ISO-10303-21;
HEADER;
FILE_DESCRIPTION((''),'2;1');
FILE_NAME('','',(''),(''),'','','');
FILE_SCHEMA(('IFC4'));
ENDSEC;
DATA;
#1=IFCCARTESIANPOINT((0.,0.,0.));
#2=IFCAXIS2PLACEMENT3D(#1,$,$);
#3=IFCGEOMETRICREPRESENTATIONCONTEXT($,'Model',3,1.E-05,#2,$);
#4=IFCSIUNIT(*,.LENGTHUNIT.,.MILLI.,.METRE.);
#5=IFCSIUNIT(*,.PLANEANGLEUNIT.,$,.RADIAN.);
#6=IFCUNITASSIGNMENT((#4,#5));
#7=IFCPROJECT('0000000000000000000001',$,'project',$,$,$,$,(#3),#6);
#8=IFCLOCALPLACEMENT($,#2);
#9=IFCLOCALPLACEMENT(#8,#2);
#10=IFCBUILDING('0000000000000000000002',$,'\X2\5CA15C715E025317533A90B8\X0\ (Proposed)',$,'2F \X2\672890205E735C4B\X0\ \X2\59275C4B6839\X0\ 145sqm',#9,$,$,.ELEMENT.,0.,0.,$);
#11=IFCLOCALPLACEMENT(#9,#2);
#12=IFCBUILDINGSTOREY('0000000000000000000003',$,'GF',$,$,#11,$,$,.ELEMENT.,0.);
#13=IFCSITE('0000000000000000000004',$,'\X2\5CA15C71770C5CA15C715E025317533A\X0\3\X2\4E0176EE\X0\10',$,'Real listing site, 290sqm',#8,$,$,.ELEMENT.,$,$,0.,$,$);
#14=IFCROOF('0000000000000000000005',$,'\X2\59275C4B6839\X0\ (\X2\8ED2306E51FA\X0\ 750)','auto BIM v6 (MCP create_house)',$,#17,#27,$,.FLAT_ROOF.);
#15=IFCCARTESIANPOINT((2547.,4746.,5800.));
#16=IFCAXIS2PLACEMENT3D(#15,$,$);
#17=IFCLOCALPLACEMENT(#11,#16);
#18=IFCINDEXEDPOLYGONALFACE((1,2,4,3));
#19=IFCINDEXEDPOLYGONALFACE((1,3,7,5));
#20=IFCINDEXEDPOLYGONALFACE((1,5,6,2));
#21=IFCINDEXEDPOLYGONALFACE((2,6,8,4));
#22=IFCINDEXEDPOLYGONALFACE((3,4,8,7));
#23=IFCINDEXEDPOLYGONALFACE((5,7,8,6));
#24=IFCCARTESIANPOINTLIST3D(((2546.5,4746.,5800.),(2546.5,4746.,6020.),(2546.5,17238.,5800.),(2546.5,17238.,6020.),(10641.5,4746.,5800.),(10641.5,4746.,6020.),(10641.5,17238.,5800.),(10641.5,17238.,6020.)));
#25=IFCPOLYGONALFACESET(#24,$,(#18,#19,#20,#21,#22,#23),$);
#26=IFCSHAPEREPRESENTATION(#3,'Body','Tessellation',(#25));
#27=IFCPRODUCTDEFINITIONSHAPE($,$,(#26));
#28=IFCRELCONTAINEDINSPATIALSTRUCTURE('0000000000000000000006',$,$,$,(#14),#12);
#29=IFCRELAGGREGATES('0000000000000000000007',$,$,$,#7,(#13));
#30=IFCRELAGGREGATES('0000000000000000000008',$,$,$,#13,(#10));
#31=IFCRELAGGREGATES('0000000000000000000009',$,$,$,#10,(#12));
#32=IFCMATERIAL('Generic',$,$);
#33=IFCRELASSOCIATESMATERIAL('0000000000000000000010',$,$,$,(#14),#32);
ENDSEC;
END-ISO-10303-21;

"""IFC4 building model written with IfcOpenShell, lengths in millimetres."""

from ifc_helpers import new_model, si_unit, frame, frame_2d, origin, place, context, project, spatial, rectangle, extrude, material, element, save


model = new_model("IFC4")

# Units and contexts
model_context = context("Model", 3, precision=1e-05, world=origin())
ifc_project = project(units=[si_unit("LENGTHUNIT", "METRE", prefix="MILLI"), si_unit("PLANEANGLEUNIT", "RADIAN")], contexts=[model_context])

# Site, building, storey
site_placement = place(None, origin())
site = spatial("IfcSite", under=ifc_project, at=site_placement, Name="岡山県岡山市北区3丁目10", ObjectType="Real listing site, 290sqm", CompositionType="ELEMENT", RefElevation=0.0)
building_placement = place(site_placement, origin())
building = spatial("IfcBuilding", under=site, at=building_placement, Name="岡山市北区邸 (Proposed)", ObjectType="2F 木造平屋 大屋根 145sqm", CompositionType="ELEMENT", ElevationOfRefHeight=0.0, ElevationOfTerrain=0.0)
storey_placement = place(building_placement, origin())
storey = spatial("IfcBuildingStorey", under=building, at=storey_placement, Name="GF", CompositionType="ELEMENT", Elevation=0.0)

# Shared definitions
ifc_material = material(Name="Generic")

# Roof
roof_placement = place(storey_placement, frame((2547.0, 4746.0, 5800.0)))
element("IfcRoof", 1, at=roof_placement, inside=storey, material=ifc_material, Name="大屋根 (軒の出 750)", Description="auto BIM v6 (MCP create_house)", PredefinedType="FLAT_ROOF", context=model_context, shape_type="SweptSolid", body=[
    extrude(rectangle(XDim=8095.0, YDim=12492.0, at=frame_2d((4047.0, 6246.0))), frame((2547.0, 4746.0, 5800.0)), (0.0, 0.0, 1.0), 220.0),
])

save(model, "model.ifc")
